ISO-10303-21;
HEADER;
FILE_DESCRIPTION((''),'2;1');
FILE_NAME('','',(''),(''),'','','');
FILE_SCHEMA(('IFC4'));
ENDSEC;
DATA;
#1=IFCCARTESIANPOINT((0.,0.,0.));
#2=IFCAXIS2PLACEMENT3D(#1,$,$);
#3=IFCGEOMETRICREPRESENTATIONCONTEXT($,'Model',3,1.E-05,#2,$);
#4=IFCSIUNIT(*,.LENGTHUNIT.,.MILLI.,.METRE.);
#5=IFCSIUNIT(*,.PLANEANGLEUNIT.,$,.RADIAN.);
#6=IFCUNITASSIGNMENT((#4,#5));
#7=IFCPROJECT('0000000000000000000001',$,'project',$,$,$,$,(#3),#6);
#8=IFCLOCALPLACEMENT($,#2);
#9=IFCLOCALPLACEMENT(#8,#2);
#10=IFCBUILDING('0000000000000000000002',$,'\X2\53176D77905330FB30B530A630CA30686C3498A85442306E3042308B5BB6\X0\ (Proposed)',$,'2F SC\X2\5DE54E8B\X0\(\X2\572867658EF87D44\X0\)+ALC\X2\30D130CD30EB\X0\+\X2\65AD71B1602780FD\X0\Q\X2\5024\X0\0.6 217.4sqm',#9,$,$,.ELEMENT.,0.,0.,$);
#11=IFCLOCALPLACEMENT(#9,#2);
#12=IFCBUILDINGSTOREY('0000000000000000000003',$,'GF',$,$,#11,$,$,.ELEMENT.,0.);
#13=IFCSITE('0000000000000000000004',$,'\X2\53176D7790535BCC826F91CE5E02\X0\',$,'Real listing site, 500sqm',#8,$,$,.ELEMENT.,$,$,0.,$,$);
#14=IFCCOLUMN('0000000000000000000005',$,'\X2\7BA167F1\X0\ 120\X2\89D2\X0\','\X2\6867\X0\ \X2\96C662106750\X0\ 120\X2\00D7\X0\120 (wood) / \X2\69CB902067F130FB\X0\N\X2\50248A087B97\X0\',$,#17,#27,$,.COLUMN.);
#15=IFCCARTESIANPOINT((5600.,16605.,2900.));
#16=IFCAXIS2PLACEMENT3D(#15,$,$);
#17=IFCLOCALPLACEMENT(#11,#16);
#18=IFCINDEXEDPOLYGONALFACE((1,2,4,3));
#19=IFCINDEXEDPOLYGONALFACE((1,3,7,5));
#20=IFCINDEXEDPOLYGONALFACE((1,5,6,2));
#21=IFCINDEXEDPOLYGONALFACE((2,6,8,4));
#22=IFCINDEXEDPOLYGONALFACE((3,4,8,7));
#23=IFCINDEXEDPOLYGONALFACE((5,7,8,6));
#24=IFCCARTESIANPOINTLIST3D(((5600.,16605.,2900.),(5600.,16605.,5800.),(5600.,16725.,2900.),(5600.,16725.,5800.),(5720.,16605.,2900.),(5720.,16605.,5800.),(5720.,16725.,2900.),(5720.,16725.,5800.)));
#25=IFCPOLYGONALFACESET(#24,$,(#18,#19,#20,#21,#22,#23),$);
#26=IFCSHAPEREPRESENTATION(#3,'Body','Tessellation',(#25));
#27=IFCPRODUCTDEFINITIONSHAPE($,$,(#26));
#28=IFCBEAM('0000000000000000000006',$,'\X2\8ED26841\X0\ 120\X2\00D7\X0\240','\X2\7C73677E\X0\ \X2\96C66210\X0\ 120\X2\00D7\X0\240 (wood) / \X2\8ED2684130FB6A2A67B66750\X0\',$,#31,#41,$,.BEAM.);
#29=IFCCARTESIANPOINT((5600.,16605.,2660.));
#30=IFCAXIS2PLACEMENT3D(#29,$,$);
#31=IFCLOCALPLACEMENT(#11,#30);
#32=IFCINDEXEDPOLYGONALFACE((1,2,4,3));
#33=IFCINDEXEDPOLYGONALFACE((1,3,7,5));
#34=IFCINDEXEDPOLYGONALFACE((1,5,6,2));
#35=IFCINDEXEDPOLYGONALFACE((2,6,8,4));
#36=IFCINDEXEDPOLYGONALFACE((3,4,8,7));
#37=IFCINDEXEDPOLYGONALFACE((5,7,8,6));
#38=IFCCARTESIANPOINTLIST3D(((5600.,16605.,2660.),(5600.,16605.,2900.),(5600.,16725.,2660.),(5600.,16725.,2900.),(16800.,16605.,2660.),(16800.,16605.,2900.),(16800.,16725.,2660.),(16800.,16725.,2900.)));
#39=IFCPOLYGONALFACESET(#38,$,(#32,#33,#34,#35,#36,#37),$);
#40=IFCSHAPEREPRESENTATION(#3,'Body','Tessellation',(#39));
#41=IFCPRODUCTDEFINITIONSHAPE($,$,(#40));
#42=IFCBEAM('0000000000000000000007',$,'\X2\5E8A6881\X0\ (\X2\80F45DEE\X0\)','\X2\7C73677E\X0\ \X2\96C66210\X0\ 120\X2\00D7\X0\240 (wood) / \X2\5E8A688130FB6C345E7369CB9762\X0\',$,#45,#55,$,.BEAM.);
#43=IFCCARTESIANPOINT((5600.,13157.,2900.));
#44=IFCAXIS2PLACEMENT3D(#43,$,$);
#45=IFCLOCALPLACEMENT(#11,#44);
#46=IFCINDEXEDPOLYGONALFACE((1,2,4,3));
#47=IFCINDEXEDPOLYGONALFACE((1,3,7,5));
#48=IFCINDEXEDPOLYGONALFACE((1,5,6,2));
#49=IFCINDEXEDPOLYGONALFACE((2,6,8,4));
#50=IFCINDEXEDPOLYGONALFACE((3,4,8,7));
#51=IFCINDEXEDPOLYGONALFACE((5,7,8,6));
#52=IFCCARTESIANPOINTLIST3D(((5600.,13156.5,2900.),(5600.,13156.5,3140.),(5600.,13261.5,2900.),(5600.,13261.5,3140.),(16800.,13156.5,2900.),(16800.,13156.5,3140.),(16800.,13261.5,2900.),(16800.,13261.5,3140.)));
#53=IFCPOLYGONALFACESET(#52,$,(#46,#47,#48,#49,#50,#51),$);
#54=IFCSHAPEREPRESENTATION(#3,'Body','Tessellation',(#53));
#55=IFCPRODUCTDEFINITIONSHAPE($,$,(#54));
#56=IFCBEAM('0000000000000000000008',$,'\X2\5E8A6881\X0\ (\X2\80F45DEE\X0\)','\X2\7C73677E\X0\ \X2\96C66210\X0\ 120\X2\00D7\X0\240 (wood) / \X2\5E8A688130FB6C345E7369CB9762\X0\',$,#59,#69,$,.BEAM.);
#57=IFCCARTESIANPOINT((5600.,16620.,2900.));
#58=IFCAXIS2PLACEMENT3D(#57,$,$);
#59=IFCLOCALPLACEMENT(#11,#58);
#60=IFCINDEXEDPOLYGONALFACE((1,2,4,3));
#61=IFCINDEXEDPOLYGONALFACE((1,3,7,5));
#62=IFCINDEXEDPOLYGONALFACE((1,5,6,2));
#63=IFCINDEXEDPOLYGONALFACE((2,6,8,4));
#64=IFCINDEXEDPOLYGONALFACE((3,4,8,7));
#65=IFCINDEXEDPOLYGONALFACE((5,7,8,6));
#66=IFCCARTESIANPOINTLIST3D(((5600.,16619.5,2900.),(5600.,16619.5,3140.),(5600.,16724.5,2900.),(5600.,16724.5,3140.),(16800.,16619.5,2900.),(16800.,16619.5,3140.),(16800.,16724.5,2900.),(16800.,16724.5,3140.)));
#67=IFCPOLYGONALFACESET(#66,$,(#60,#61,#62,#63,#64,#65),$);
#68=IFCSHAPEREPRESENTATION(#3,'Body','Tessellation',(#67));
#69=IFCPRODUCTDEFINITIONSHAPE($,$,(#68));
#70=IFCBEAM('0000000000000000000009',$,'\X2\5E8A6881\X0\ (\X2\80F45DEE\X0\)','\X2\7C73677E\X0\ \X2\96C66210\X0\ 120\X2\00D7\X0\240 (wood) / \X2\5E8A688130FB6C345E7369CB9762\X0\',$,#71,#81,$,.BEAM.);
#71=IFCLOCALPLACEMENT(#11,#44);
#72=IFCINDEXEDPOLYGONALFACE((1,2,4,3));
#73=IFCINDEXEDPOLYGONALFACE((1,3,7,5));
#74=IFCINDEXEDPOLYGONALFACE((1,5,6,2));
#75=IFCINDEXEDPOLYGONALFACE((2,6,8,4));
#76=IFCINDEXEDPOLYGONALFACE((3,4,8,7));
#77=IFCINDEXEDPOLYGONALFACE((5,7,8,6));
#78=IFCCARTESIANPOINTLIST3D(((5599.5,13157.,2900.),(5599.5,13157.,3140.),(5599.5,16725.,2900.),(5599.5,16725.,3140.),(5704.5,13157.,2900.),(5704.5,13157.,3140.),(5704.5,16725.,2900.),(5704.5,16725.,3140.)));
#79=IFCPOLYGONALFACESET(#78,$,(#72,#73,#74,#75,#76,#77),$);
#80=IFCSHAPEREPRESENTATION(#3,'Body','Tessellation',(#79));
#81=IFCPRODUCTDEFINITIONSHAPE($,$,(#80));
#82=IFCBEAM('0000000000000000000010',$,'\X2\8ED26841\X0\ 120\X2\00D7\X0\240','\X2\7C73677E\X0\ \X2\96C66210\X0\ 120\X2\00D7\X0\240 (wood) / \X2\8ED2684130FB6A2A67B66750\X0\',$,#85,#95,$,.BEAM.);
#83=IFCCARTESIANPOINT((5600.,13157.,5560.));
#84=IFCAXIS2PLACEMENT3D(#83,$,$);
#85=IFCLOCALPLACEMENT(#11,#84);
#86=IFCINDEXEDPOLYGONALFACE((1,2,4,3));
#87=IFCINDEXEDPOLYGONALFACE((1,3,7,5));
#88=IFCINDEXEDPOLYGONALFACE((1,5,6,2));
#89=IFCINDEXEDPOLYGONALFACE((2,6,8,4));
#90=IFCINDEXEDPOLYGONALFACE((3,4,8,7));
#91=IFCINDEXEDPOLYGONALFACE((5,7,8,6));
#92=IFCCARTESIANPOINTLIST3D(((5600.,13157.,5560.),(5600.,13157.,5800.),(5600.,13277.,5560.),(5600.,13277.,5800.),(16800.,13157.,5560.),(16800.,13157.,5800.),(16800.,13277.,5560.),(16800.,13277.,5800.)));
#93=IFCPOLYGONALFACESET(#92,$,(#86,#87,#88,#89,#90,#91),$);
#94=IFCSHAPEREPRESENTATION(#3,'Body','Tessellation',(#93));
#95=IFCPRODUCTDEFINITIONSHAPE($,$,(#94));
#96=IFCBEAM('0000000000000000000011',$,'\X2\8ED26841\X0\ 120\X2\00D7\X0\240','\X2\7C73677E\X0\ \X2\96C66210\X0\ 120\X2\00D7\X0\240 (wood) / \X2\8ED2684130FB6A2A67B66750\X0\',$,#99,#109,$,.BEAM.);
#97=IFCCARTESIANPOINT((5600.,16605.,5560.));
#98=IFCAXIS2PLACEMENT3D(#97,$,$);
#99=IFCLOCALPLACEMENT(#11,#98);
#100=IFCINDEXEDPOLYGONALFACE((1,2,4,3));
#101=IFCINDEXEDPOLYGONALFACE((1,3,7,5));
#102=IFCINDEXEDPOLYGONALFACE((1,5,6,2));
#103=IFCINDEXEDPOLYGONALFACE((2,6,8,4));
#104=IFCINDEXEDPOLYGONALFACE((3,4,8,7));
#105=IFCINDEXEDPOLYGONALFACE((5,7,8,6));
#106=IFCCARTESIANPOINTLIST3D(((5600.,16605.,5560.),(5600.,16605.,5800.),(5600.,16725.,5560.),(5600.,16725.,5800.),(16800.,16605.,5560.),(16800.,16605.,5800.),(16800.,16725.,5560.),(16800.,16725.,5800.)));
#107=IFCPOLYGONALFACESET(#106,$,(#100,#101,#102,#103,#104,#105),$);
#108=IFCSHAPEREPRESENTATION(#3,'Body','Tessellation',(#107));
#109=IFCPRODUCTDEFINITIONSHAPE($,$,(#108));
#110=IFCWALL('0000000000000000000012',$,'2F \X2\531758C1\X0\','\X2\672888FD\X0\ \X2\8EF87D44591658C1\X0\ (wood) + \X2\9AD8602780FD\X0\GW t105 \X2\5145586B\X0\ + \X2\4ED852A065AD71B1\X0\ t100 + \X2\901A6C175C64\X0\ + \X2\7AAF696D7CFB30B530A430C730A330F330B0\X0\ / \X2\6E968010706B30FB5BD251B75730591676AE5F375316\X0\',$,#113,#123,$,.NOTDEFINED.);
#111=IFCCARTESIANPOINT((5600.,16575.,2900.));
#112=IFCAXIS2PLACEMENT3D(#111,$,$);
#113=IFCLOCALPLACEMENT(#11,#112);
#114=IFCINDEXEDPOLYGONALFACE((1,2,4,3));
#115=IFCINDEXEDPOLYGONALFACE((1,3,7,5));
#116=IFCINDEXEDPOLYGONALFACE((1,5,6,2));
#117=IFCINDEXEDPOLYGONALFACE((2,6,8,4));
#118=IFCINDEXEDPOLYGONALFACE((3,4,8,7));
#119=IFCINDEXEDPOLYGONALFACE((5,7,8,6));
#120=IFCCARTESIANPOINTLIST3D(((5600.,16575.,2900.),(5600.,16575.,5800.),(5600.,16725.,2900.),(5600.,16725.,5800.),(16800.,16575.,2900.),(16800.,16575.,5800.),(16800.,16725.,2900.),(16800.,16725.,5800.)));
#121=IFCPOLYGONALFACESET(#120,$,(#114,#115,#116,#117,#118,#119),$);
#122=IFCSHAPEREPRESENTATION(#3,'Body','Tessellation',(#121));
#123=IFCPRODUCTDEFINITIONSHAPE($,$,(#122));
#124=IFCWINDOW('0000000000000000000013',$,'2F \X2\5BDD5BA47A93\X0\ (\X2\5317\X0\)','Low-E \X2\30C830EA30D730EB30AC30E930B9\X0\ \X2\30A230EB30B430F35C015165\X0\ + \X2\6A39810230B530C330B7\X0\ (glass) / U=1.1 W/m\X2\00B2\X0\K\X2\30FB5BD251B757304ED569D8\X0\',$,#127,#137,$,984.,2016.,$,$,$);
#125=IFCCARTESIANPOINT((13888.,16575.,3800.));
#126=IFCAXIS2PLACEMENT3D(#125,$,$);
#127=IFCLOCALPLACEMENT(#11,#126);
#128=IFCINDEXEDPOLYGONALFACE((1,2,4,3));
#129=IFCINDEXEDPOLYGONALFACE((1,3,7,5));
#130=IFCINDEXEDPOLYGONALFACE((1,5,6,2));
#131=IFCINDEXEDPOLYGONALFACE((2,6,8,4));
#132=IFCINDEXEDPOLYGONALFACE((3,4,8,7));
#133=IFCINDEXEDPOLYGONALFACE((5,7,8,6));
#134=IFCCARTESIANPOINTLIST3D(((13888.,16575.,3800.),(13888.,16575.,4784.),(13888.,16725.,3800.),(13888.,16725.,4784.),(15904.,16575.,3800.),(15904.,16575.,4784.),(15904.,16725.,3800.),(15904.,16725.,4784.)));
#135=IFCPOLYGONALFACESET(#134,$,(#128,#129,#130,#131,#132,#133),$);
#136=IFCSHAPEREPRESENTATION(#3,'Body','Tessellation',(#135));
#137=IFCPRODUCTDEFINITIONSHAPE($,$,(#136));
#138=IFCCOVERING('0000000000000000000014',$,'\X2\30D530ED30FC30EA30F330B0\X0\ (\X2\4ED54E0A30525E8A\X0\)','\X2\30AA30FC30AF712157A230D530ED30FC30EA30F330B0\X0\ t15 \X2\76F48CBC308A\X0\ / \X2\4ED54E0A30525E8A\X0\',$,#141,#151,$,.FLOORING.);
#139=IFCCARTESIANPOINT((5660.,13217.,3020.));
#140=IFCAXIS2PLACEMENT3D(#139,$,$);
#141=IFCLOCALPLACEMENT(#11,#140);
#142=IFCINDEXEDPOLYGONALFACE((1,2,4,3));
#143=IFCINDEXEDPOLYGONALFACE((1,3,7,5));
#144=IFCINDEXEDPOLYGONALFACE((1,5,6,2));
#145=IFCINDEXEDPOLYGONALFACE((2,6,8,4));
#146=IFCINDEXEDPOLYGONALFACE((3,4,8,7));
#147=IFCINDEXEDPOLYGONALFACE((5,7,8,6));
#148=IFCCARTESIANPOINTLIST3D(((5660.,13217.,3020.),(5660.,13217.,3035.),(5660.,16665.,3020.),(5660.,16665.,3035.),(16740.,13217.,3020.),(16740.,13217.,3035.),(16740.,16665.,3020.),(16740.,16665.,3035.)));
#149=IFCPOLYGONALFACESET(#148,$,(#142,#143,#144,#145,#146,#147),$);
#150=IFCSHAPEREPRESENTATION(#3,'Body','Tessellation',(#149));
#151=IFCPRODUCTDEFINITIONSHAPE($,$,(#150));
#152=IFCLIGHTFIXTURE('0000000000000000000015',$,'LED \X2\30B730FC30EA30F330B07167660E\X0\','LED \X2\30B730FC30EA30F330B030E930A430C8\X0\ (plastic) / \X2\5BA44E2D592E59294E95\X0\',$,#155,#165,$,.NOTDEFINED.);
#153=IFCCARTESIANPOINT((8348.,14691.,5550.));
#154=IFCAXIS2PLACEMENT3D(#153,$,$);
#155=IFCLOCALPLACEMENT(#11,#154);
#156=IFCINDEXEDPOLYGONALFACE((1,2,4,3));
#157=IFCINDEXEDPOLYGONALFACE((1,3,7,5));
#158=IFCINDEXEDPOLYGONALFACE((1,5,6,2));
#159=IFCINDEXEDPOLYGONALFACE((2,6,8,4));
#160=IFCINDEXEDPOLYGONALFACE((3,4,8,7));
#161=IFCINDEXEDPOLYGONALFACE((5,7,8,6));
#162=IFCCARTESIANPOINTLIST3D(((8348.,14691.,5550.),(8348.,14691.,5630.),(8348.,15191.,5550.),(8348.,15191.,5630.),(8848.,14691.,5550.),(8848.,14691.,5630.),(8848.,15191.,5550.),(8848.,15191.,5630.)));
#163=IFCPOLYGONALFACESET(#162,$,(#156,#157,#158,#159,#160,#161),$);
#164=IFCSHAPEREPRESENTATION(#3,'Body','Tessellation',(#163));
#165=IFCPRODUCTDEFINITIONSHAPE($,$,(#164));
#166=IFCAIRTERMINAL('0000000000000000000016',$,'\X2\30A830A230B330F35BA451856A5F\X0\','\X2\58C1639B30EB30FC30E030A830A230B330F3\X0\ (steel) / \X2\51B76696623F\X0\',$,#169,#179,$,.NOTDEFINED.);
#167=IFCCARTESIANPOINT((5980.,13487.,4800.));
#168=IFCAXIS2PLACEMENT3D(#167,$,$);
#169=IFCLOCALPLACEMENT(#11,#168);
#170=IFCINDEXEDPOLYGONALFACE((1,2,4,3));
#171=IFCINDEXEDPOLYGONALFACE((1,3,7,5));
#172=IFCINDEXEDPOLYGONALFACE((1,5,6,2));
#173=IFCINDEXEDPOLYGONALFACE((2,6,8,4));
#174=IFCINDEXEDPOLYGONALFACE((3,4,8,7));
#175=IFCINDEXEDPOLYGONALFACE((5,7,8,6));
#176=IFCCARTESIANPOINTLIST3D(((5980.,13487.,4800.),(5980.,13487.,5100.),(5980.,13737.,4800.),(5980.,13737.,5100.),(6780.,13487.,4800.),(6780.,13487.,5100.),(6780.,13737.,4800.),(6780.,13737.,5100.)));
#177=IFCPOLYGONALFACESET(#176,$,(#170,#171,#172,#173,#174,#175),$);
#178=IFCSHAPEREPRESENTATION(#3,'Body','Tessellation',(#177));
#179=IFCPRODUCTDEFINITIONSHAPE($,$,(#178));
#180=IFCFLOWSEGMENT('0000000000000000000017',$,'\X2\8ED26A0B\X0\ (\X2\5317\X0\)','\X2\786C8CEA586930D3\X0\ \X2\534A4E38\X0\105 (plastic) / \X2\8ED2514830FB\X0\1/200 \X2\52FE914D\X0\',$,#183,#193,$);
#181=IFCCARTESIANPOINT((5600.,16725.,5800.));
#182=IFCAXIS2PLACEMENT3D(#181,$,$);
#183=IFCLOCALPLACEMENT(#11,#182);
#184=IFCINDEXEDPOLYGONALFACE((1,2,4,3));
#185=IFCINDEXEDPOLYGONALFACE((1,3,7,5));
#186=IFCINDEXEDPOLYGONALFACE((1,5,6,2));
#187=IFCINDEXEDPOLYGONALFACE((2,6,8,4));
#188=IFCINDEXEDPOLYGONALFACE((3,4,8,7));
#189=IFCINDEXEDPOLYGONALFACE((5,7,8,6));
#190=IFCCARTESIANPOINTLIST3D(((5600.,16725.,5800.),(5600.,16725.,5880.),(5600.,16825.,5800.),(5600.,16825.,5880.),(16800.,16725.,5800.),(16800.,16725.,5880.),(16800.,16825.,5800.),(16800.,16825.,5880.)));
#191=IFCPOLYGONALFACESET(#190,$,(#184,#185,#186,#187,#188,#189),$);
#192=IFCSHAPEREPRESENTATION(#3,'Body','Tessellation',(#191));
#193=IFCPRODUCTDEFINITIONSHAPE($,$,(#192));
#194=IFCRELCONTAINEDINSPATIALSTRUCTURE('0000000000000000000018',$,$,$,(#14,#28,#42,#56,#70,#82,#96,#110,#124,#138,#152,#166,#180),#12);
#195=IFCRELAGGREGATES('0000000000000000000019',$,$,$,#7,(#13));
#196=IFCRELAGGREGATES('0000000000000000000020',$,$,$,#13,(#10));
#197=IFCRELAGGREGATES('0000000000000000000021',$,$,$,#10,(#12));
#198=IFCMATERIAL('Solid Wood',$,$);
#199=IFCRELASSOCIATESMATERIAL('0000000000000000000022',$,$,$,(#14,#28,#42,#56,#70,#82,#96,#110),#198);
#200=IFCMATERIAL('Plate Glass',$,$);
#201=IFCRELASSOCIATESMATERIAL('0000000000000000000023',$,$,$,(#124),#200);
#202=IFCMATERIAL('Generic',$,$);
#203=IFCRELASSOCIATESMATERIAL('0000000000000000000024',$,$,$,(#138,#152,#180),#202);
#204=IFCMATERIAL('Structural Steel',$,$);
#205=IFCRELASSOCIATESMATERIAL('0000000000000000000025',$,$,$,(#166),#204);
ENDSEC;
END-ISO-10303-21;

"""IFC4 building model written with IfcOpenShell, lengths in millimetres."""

from ifc_helpers import new_model, si_unit, frame, frame_2d, origin, place, context, project, spatial, rectangle, extrude, material, element, fill, save


model = new_model("IFC4")

# Units and contexts
model_context = context("Model", 3, precision=1e-05, world=origin())
ifc_project = project(units=[si_unit("LENGTHUNIT", "METRE", prefix="MILLI"), si_unit("PLANEANGLEUNIT", "RADIAN")], contexts=[model_context])

# Site, building, storey
site_placement = place(None, origin())
site = spatial("IfcSite", under=ifc_project, at=site_placement, Name="北海道富良野市", ObjectType="Real listing site, 500sqm", CompositionType="ELEMENT", RefElevation=0.0)
building_placement = place(site_placement, origin())
building = spatial("IfcBuilding", under=site, at=building_placement, Name="北海道・サウナと水風呂のある家 (Proposed)", ObjectType="2F SC工事(在来軸組)+ALCパネル+断熱性能Q値0.6 217.4sqm", CompositionType="ELEMENT", ElevationOfRefHeight=0.0, ElevationOfTerrain=0.0)
storey_placement = place(building_placement, origin())
storey = spatial("IfcBuildingStorey", under=building, at=storey_placement, Name="GF", CompositionType="ELEMENT", Elevation=0.0)

# Column
ifc_material_1 = material(Name="Solid Wood")
column_1_placement = place(storey_placement, frame((5600.0, 16605.0, 2900.0)))
element("IfcColumn", 1, at=column_1_placement, inside=storey, material=ifc_material_1, Name="管柱 120角", Description="桧 集成材 120×120 (wood) / 構造柱・N値計算", PredefinedType="COLUMN", context=model_context, shape_type="SweptSolid", body=[
    extrude(rectangle(XDim=120.0, YDim=120.0, at=frame_2d((60.0, 60.0))), frame((5600.0, 16605.0, 2900.0)), (0.0, 0.0, 1.0), 2900.0),
])

# Beams
beam_1_placement = place(storey_placement, frame((5600.0, 16605.0, 2660.0)))
element("IfcBeam", 2, at=beam_1_placement, inside=storey, material=ifc_material_1, Name="軒桁 120×240", Description="米松 集成 120×240 (wood) / 軒桁・横架材", PredefinedType="BEAM", context=model_context, shape_type="SweptSolid", body=[
    extrude(rectangle(XDim=11200.0, YDim=120.0, at=frame_2d((5600.0, 60.0))), frame((5600.0, 16605.0, 2660.0)), (0.0, 0.0, 1.0), 240.0),
])
beam_2_placement = place(storey_placement, frame((5600.0, 13157.0, 2900.0)))
element("IfcBeam", 3, at=beam_2_placement, inside=storey, material=ifc_material_1, Name="床梁 (胴差)", Description="米松 集成 120×240 (wood) / 床梁・水平構面", PredefinedType="BEAM", context=model_context, shape_type="SweptSolid", body=[
    extrude(rectangle(XDim=11200.0, YDim=105.0, at=frame_2d((5600.0, 52.0))), frame((5600.0, 13157.0, 2900.0)), (0.0, 0.0, 1.0), 240.0),
])
beam_3_placement = place(storey_placement, frame((5600.0, 16620.0, 2900.0)))
element("IfcBeam", 4, at=beam_3_placement, inside=storey, material=ifc_material_1, Name="床梁 (胴差)", Description="米松 集成 120×240 (wood) / 床梁・水平構面", PredefinedType="BEAM", context=model_context, shape_type="SweptSolid", body=[
    extrude(rectangle(XDim=11200.0, YDim=105.0, at=frame_2d((5600.0, 52.0))), frame((5600.0, 16620.0, 2900.0)), (0.0, 0.0, 1.0), 240.0),
])
beam_4_placement = place(storey_placement, frame((5600.0, 13157.0, 2900.0)))
element("IfcBeam", 5, at=beam_4_placement, inside=storey, material=ifc_material_1, Name="床梁 (胴差)", Description="米松 集成 120×240 (wood) / 床梁・水平構面", PredefinedType="BEAM", context=model_context, shape_type="SweptSolid", body=[
    extrude(rectangle(XDim=105.0, YDim=3568.0, at=frame_2d((52.0, 1784.0))), frame((5600.0, 13157.0, 2900.0)), (0.0, 0.0, 1.0), 240.0),
])
beam_5_placement = place(storey_placement, frame((5600.0, 13157.0, 5560.0)))
element("IfcBeam", 6, at=beam_5_placement, inside=storey, material=ifc_material_1, Name="軒桁 120×240", Description="米松 集成 120×240 (wood) / 軒桁・横架材", PredefinedType="BEAM", context=model_context, shape_type="SweptSolid", body=[
    extrude(rectangle(XDim=11200.0, YDim=120.0, at=frame_2d((5600.0, 60.0))), frame((5600.0, 13157.0, 5560.0)), (0.0, 0.0, 1.0), 240.0),
])
beam_6_placement = place(storey_placement, frame((5600.0, 16605.0, 5560.0)))
element("IfcBeam", 7, at=beam_6_placement, inside=storey, material=ifc_material_1, Name="軒桁 120×240", Description="米松 集成 120×240 (wood) / 軒桁・横架材", PredefinedType="BEAM", context=model_context, shape_type="SweptSolid", body=[
    extrude(rectangle(XDim=11200.0, YDim=120.0, at=frame_2d((5600.0, 60.0))), frame((5600.0, 16605.0, 5560.0)), (0.0, 0.0, 1.0), 240.0),
])

# Wall, opening, window
wall_placement = place(storey_placement, frame((5600.0, 16575.0, 2900.0)))
wall = element("IfcWall", 8, at=wall_placement, inside=storey, material=ifc_material_1, Name="2F 北壁", Description="木製 軸組外壁 (wood) + 高性能GW t105 充填 + 付加断熱 t100 + 通気層 + 窯業系サイディング / 準耐火・寒冷地外皮強化", PredefinedType="NOTDEFINED", context=model_context, shape_type="SweptSolid", body=[
    extrude(rectangle(XDim=11200.0, YDim=150.0, at=frame_2d((5600.0, 75.0))), frame((5600.0, 16575.0, 2900.0)), (0.0, 0.0, 1.0), 2900.0),
])
opening_placement = place(storey_placement, frame((13888.0, 16575.0, 3800.0)))
opening = element("IfcOpeningElement", 9, at=opening_placement, cuts=wall, PredefinedType="NOTDEFINED", context=model_context, shape_type="SweptSolid", body=[
    extrude(rectangle(XDim=2016.0, YDim=150.0, at=frame_2d((1008.0, 75.0))), frame((13888.0, 16575.0, 3800.0)), (0.0, 0.0, 1.0), 984.0),
])
ifc_material_2 = material(Name="Plate Glass")
window_placement = place(storey_placement, frame((13888.0, 16575.0, 3800.0)))
window = element("IfcWindow", 10, at=window_placement, inside=storey, material=ifc_material_2, Name="2F 寝室窓 (北)", Description="Low-E トリプルガラス アルゴン封入 + 樹脂サッシ (glass) / U=1.1 W/m²K・寒冷地仕様", OverallHeight=984.0, OverallWidth=2016.0, context=model_context, shape_type="SweptSolid", body=[
    extrude(rectangle(XDim=2016.0, YDim=150.0, at=frame_2d((1008.0, 75.0))), frame((13888.0, 16575.0, 3800.0)), (0.0, 0.0, 1.0), 984.0),
])
fill(opening, window)

# Covering
ifc_material_3 = material(Name="Generic")
covering_placement = place(storey_placement, frame((5660.0, 13217.0, 3020.0)))
element("IfcCovering", 11, at=covering_placement, inside=storey, material=ifc_material_3, Name="フローリング (仕上げ床)", Description="オーク無垢フローリング t15 直貼り / 仕上げ床", PredefinedType="FLOORING", context=model_context, shape_type="SweptSolid", body=[
    extrude(rectangle(XDim=11080.0, YDim=3448.0, at=frame_2d((5540.0, 1724.0))), frame((5660.0, 13217.0, 3020.0)), (0.0, 0.0, 1.0), 15.0),
])

# Light fixture
light_fixture_placement = place(storey_placement, frame((8348.0, 14691.0, 5550.0)))
element("IfcLightFixture", 12, at=light_fixture_placement, inside=storey, material=ifc_material_3, Name="LED シーリング照明", Description="LED シーリングライト (plastic) / 室中央天井", PredefinedType="NOTDEFINED", context=model_context, shape_type="SweptSolid", body=[
    extrude(rectangle(XDim=500.0, YDim=500.0, at=frame_2d((250.0, 250.0))), frame((8348.0, 14691.0, 5550.0)), (0.0, 0.0, 1.0), 80.0),
])

# Air terminal
ifc_material_4 = material(Name="Structural Steel")
air_terminal_placement = place(storey_placement, frame((5980.0, 13487.0, 4800.0)))
element("IfcAirTerminal", 13, at=air_terminal_placement, inside=storey, material=ifc_material_4, Name="エアコン室内機", Description="壁掛ルームエアコン (steel) / 冷暖房", PredefinedType="NOTDEFINED", context=model_context, shape_type="SweptSolid", body=[
    extrude(rectangle(XDim=800.0, YDim=250.0, at=frame_2d((400.0, 125.0))), frame((5980.0, 13487.0, 4800.0)), (0.0, 0.0, 1.0), 300.0),
])

# Flow segment
flow_segment_placement = place(storey_placement, frame((5600.0, 16725.0, 5800.0)))
element("IfcFlowSegment", 14, at=flow_segment_placement, inside=storey, material=ifc_material_3, Name="軒樋 (北)", Description="硬質塩ビ 半丸105 (plastic) / 軒先・1/200 勾配", context=model_context, shape_type="SweptSolid", body=[
    extrude(rectangle(XDim=11200.0, YDim=100.0, at=frame_2d((5600.0, 50.0))), frame((5600.0, 16725.0, 5800.0)), (0.0, 0.0, 1.0), 80.0),
])

save(model, "model.ifc")
